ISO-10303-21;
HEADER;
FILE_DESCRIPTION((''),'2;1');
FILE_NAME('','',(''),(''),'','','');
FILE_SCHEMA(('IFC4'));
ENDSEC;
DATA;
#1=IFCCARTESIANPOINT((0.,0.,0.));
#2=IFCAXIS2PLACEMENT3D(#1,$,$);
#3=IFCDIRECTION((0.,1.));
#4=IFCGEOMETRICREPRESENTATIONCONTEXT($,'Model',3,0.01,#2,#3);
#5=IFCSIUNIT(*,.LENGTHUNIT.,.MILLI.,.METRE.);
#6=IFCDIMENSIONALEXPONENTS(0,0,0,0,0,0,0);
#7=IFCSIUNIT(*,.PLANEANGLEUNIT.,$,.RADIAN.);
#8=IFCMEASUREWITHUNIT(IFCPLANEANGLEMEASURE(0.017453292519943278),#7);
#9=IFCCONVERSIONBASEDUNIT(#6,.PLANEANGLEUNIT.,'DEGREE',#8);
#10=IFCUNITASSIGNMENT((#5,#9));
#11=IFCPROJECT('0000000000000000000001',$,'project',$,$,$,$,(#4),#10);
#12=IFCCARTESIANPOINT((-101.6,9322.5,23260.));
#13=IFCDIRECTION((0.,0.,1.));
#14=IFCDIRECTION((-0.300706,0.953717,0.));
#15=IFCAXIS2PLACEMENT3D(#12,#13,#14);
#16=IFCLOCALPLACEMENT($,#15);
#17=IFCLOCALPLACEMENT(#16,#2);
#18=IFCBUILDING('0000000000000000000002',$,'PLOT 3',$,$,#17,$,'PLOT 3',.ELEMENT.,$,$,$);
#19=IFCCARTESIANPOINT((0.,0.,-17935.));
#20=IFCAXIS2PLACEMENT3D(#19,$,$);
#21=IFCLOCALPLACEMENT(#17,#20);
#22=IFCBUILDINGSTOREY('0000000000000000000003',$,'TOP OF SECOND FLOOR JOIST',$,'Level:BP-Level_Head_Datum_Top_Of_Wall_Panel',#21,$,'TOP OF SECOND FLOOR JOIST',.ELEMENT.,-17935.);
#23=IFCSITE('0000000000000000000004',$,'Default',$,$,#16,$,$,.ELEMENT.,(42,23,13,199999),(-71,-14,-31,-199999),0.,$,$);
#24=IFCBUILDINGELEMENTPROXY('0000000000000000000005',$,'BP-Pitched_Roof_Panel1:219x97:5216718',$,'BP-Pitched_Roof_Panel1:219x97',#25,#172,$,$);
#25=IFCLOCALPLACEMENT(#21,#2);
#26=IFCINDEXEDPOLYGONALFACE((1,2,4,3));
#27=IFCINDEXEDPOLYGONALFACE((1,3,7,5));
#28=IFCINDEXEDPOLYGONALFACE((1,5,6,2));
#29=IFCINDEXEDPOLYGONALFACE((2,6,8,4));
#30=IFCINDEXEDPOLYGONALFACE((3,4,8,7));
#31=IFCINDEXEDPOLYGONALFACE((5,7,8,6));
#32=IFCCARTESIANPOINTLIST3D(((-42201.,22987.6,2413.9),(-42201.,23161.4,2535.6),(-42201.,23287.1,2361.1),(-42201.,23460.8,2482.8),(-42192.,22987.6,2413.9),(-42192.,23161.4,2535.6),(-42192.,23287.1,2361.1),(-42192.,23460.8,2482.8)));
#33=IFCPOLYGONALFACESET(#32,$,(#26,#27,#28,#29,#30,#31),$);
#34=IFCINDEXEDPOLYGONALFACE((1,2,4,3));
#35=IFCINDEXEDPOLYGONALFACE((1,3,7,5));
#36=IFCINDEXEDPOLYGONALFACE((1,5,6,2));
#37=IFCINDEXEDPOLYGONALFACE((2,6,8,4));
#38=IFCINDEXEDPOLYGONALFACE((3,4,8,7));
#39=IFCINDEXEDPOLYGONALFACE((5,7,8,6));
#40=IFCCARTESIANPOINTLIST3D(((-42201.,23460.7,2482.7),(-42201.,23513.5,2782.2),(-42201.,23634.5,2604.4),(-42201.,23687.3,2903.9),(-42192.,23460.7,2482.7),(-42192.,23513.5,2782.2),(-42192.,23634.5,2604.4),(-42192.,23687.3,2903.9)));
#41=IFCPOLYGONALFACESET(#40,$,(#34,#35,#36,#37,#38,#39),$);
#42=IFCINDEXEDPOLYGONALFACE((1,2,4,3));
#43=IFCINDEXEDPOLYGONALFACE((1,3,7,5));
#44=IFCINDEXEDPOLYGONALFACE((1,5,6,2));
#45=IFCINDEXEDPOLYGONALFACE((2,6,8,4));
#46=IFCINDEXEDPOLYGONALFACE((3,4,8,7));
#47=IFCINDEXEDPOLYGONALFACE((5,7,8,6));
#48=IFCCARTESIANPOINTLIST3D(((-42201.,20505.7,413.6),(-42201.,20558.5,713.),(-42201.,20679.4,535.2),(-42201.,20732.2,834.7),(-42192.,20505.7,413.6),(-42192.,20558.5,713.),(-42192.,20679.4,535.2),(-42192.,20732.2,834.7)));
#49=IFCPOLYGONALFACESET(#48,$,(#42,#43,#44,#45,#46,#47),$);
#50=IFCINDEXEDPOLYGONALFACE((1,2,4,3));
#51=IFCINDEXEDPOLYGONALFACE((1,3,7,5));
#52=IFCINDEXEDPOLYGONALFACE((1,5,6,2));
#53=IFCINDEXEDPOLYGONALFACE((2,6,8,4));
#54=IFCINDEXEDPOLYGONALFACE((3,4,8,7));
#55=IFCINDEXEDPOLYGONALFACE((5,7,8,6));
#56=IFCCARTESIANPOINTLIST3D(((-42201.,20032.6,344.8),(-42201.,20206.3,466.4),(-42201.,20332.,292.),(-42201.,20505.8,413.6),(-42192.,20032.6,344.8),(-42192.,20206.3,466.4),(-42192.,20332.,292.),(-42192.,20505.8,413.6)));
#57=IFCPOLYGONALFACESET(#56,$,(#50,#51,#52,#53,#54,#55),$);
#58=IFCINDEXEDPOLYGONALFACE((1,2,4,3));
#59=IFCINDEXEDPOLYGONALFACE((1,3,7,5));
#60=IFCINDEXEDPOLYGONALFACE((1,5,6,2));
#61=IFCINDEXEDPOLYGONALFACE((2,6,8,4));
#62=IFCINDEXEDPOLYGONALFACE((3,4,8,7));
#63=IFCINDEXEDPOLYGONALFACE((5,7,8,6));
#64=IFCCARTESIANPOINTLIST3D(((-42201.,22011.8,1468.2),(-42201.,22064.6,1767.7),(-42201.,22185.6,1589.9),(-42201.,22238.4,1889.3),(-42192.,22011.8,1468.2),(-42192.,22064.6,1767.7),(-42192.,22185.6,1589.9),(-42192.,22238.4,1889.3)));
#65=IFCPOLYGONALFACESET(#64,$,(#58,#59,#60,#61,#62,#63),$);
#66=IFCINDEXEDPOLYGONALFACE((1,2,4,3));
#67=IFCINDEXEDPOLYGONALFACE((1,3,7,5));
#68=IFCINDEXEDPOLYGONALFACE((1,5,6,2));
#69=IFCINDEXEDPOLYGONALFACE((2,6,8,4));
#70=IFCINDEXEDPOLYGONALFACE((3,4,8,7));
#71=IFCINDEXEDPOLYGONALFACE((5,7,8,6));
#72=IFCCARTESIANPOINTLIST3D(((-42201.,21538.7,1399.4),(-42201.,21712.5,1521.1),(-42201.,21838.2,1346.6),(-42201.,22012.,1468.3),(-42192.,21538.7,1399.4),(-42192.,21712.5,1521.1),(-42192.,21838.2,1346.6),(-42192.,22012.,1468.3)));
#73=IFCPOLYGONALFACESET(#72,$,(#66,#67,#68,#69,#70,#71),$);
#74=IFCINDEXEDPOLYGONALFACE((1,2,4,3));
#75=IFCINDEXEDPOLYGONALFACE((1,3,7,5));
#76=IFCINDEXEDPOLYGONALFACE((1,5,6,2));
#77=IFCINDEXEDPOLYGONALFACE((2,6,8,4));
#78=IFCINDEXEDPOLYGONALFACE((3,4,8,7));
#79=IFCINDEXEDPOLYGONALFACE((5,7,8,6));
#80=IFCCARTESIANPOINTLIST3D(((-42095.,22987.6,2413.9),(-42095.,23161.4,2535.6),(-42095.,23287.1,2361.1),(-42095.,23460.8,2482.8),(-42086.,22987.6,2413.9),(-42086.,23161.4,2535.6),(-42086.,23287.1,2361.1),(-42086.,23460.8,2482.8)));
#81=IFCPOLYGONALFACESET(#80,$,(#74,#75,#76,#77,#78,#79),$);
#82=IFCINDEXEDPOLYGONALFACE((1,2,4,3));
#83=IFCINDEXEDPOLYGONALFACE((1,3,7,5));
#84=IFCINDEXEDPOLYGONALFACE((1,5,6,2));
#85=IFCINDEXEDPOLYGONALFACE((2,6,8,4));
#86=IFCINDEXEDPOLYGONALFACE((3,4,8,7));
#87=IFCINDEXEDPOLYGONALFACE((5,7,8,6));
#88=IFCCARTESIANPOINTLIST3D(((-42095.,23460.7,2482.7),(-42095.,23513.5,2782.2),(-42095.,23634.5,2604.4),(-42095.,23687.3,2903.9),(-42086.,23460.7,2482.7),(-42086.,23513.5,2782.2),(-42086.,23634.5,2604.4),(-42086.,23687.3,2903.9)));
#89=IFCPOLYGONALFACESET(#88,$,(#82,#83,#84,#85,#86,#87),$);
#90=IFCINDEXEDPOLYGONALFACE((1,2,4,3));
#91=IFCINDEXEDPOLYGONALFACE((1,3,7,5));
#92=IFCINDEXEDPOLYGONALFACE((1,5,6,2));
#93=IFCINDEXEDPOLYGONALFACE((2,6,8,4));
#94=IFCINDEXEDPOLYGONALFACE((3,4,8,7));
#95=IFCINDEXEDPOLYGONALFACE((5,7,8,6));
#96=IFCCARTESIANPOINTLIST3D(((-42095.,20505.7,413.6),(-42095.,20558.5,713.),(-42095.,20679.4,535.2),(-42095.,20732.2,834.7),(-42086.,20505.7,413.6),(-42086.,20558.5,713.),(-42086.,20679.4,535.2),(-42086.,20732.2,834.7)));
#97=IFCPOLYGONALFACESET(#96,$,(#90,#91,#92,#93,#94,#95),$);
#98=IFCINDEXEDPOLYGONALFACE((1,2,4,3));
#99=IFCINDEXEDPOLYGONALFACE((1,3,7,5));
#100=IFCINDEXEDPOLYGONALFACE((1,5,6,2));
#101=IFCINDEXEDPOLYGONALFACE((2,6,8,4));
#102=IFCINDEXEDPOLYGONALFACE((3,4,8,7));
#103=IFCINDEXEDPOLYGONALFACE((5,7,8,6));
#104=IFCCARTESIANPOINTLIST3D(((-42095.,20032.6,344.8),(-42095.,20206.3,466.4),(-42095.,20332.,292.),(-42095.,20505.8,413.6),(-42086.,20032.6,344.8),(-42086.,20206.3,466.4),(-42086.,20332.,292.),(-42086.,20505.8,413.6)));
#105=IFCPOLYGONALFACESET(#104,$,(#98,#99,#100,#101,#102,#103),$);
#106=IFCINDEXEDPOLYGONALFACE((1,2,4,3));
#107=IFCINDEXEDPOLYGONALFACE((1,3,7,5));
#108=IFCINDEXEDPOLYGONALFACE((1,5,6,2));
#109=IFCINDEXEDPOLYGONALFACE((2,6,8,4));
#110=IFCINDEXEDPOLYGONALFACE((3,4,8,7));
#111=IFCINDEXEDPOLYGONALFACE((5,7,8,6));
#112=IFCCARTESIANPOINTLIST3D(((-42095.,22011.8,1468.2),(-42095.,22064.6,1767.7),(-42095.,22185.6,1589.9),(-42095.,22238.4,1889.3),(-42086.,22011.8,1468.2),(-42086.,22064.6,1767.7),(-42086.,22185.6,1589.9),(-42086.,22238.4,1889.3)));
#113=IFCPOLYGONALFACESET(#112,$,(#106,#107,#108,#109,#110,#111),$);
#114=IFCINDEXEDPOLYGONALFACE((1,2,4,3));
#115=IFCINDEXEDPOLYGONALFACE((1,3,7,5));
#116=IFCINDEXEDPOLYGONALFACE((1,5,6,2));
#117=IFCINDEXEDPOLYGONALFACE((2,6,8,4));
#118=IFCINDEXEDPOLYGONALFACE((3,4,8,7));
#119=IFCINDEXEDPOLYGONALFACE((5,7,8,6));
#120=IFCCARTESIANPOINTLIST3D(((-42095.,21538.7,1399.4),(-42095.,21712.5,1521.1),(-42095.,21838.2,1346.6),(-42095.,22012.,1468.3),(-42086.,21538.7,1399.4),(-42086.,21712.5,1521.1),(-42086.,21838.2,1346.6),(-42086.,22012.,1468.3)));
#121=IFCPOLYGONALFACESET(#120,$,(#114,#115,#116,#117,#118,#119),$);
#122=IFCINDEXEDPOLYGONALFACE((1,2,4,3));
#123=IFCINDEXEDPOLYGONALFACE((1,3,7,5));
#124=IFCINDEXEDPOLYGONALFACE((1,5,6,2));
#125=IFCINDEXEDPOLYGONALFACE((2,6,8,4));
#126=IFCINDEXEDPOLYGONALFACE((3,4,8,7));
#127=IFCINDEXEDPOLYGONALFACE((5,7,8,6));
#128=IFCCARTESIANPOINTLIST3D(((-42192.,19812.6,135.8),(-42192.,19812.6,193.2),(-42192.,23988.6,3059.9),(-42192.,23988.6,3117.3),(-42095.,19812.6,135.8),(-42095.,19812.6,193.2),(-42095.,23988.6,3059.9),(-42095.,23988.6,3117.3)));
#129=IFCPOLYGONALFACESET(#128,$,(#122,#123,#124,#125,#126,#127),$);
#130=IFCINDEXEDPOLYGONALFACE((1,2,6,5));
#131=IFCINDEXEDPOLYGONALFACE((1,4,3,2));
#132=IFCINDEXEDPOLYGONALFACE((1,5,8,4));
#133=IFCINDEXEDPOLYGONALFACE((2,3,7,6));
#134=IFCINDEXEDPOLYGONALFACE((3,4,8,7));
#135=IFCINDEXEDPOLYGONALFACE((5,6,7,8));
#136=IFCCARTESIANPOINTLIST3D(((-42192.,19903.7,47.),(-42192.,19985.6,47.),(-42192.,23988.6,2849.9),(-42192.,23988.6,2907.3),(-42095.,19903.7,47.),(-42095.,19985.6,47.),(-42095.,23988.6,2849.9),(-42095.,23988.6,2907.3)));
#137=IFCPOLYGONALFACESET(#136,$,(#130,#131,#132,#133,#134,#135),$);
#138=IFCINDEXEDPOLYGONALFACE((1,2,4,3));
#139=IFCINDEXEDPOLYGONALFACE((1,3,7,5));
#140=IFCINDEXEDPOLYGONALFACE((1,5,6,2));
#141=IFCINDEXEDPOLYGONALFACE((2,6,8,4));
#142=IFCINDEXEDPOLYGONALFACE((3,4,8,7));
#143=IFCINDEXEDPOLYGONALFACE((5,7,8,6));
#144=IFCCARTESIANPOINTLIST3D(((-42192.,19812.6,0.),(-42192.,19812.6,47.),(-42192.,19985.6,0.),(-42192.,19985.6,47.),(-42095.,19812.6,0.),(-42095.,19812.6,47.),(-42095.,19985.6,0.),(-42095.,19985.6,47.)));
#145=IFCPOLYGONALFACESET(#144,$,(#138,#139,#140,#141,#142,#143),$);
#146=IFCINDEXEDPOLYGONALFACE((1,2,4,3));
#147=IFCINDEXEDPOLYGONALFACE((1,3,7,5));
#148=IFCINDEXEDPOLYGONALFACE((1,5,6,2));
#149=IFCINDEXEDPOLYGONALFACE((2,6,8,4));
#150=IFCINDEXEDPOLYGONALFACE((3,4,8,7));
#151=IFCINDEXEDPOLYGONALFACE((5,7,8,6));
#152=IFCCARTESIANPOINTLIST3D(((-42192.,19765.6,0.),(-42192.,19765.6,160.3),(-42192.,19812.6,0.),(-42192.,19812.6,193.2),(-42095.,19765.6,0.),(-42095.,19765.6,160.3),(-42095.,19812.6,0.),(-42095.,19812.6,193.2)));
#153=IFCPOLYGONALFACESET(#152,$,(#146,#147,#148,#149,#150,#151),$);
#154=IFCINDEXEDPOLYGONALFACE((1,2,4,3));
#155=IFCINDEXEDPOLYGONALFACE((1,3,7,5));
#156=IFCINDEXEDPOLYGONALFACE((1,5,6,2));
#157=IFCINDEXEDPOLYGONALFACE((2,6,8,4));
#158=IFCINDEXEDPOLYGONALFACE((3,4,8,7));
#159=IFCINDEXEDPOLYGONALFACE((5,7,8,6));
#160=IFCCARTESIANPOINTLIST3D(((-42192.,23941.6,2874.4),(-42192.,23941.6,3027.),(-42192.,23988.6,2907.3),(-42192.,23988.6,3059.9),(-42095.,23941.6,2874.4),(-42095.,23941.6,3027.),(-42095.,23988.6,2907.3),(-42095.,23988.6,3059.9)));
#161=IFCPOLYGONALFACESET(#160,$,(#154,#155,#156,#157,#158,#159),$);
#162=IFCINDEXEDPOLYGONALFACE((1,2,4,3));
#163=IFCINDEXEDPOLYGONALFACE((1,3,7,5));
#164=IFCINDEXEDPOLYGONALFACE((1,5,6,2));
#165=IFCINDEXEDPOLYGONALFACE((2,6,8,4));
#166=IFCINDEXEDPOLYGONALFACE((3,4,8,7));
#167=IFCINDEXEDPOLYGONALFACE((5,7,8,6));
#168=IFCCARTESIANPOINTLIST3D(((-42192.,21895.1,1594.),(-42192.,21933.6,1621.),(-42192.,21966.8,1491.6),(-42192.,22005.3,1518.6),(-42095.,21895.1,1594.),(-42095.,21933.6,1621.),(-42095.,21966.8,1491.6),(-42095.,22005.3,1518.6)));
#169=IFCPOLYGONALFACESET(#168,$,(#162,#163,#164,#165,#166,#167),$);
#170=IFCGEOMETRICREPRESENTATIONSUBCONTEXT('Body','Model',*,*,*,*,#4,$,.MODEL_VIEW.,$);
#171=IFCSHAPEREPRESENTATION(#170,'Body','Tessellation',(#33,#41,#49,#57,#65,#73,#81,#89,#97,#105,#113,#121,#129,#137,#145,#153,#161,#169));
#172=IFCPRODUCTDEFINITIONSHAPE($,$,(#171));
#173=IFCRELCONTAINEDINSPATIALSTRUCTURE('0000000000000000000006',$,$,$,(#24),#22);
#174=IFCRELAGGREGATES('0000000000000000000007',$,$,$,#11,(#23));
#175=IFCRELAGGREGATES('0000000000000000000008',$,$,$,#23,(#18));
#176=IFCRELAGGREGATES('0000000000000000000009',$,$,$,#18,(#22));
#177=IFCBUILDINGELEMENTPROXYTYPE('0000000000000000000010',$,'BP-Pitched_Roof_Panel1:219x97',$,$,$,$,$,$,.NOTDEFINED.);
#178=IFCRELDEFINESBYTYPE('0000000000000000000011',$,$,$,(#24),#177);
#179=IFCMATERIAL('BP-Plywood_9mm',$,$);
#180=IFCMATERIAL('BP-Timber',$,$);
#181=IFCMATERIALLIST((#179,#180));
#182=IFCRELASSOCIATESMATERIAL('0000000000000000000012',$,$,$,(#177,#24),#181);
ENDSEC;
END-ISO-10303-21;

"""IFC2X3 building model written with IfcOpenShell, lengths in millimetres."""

from ifc_helpers import new_model, entity, si_unit, converted_unit, direction, frame, frame_2d, origin, origin_2d_with_axis, place, context, subcontext, project, spatial, polyline, rectangle, outline, extrude, source, transform, mapped, material, material_list, type_object, type_shapes, element, save


model = new_model("IFC2X3")

# Units and contexts
model_context = context("Model", 3, precision=0.01, world=origin(), true_north=direction((0.0, 1.0)))
body_context = subcontext(model_context, "Body", "Model", "MODEL_VIEW")
ifc_project = project(units=[si_unit("LENGTHUNIT", "METRE", prefix="MILLI"), converted_unit("PLANEANGLEUNIT", "DEGREE", entity("IfcPlaneAngleMeasure", 0.017453292519943278), si_unit("PLANEANGLEUNIT", "RADIAN"), dimensions=[0, 0, 0, 0, 0, 0, 0])], contexts=[model_context])

# Site, building, storey
site_placement = place(None, frame((-101.6, 9322.5, 23260.0), z_axis=(0.0, 0.0, 1.0), x_axis=(-0.300706, 0.953717, 0.0)))
site = spatial("IfcSite", under=ifc_project, at=site_placement, Name="Default", CompositionType="ELEMENT", RefLatitude=(42, 23, 13, 199999), RefLongitude=(-71, -14, -31, -199999), RefElevation=0.0)
building_placement = place(site_placement, origin())
building = spatial("IfcBuilding", under=site, at=building_placement, Name="PLOT 3", LongName="PLOT 3", CompositionType="ELEMENT")
storey_placement = place(building_placement, frame((0.0, 0.0, -17935.0)))
storey = spatial("IfcBuildingStorey", under=building, at=storey_placement, Name="TOP OF SECOND FLOOR JOIST", ObjectType="Level:BP-Level_Head_Datum_Top_Of_Wall_Panel", LongName="TOP OF SECOND FLOOR JOIST", CompositionType="ELEMENT", Elevation=-17935.0)

# Building element proxy
ifc_material_1 = material(Name="BP-Timber")
ifc_material_2 = material(Name="BP-Plywood_9mm")
ifc_material_list = material_list([ifc_material_2, ifc_material_1])
building_element_proxy_type_1 = type_object("IfcBuildingElementProxyType", Name="BP-Pitched_Roof_Panel1:219x97", PredefinedType="NOTDEFINED", material=ifc_material_list)
shared_shape_1 = source(origin(), body_context, "Body", "SweptSolid", [
    extrude(outline(polyline([(-77.0, -75.0), (227.0, -75.0), (77.0, 75.0), (-227.0, 75.0), (-77.0, -75.0)])), frame((36.3, 3947.0, 2448.4), z_axis=(0.0, 1.0, 0.0), x_axis=(-0.984808, 0.0, 0.173648)), (0.0, 0.0, 1.0), 9.0),
    extrude(outline(polyline([(1.4, -107.5), (213.6, -107.5), (-1.4, 107.5), (-213.6, 107.5), (1.4, -107.5)])), frame((386.1, 3947.0, 2693.3), z_axis=(0.0, 1.0, 0.0), x_axis=(-0.819152, 0.0, -0.573576)), (0.0, 0.0, 1.0), 9.0),
    extrude(outline(polyline([(1.4, -107.5), (213.6, -107.5), (-1.4, 107.5), (-213.6, 107.5), (1.4, -107.5)])), frame((-2569.0, 3947.0, 624.1), z_axis=(0.0, 1.0, 0.0), x_axis=(-0.819152, 0.0, -0.573576)), (0.0, 0.0, 1.0), 9.0),
    extrude(outline(polyline([(-77.0, -75.0), (227.0, -75.0), (77.0, 75.0), (-227.0, 75.0), (-77.0, -75.0)])), frame((-2918.8, 3947.0, 379.2), z_axis=(0.0, 1.0, 0.0), x_axis=(-0.984808, 0.0, 0.173648)), (0.0, 0.0, 1.0), 9.0),
    extrude(outline(polyline([(1.4, -107.5), (213.6, -107.5), (-1.4, 107.5), (-213.6, 107.5), (1.4, -107.5)])), frame((-1062.8, 3947.0, 1678.8), z_axis=(0.0, 1.0, 0.0), x_axis=(-0.819152, 0.0, -0.573576)), (0.0, 0.0, 1.0), 9.0),
    extrude(outline(polyline([(-77.0, -75.0), (227.0, -75.0), (77.0, 75.0), (-227.0, 75.0), (-77.0, -75.0)])), frame((-1412.6, 3947.0, 1433.9), z_axis=(0.0, 1.0, 0.0), x_axis=(-0.984808, 0.0, 0.173648)), (0.0, 0.0, 1.0), 9.0),
    extrude(outline(polyline([(-77.0, -75.0), (227.0, -75.0), (77.0, 75.0), (-227.0, 75.0), (-77.0, -75.0)])), frame((36.3, 3841.0, 2448.4), z_axis=(0.0, 1.0, 0.0), x_axis=(-0.984808, 0.0, 0.173648)), (0.0, 0.0, 1.0), 9.0),
    extrude(outline(polyline([(1.4, -107.5), (213.6, -107.5), (-1.4, 107.5), (-213.6, 107.5), (1.4, -107.5)])), frame((386.1, 3841.0, 2693.3), z_axis=(0.0, 1.0, 0.0), x_axis=(-0.819152, 0.0, -0.573576)), (0.0, 0.0, 1.0), 9.0),
    extrude(outline(polyline([(1.4, -107.5), (213.6, -107.5), (-1.4, 107.5), (-213.6, 107.5), (1.4, -107.5)])), frame((-2569.0, 3841.0, 624.1), z_axis=(0.0, 1.0, 0.0), x_axis=(-0.819152, 0.0, -0.573576)), (0.0, 0.0, 1.0), 9.0),
    extrude(outline(polyline([(-77.0, -75.0), (227.0, -75.0), (77.0, 75.0), (-227.0, 75.0), (-77.0, -75.0)])), frame((-2918.8, 3841.0, 379.2), z_axis=(0.0, 1.0, 0.0), x_axis=(-0.984808, 0.0, 0.173648)), (0.0, 0.0, 1.0), 9.0),
    extrude(outline(polyline([(1.4, -107.5), (213.6, -107.5), (-1.4, 107.5), (-213.6, 107.5), (1.4, -107.5)])), frame((-1062.8, 3841.0, 1678.8), z_axis=(0.0, 1.0, 0.0), x_axis=(-0.819152, 0.0, -0.573576)), (0.0, 0.0, 1.0), 9.0),
    extrude(outline(polyline([(-77.0, -75.0), (227.0, -75.0), (77.0, 75.0), (-227.0, 75.0), (-77.0, -75.0)])), frame((-1412.6, 3841.0, 1433.9), z_axis=(0.0, 1.0, 0.0), x_axis=(-0.984808, 0.0, 0.173648)), (0.0, 0.0, 1.0), 9.0),
    extrude(outline(polyline([(-1490.7, -2088.0), (-1433.3, -2088.0), (1490.7, 2088.0), (1433.3, 2088.0), (-1490.7, -2088.0)])), frame((-1287.3, 3850.0, 1626.6), z_axis=(0.0, 1.0, 0.0), x_axis=(0.0, 0.0, -1.0)), (0.0, 0.0, 1.0), 97.0),
    extrude(outline(polyline([(-1444.5, -2022.0), (-1387.1, -2022.0), (1415.8, 1981.0), (1415.8, 2063.0), (-1444.5, -2022.0)])), frame((-1221.3, 3850.0, 1462.8), z_axis=(0.0, 1.0, 0.0), x_axis=(0.0, 0.0, -1.0)), (0.0, 0.0, 1.0), 97.0),
    extrude(rectangle(XDim=97.0, YDim=173.0, at=origin_2d_with_axis()), frame((-3288.8, 3898.5, 0.0), z_axis=(0.0, 0.0, 1.0), x_axis=(0.0, 1.0, 0.0)), (0.0, 0.0, 1.0), 47.0),
    extrude(outline(polyline([(22.0, -72.4), (79.4, -72.4), (-31.4, 85.9), (-69.9, 58.9), (22.0, -72.4)])), frame((-3398.8, 3850.0, 88.4), z_axis=(0.0, 1.0, 0.0), x_axis=(0.819152, 0.0, 0.573576)), (0.0, 0.0, 1.0), 97.0),
    extrude(outline(polyline([(15.1, -62.5), (72.5, -62.5), (-15.1, 62.5), (-72.5, 62.5), (15.1, -62.5)])), frame((777.2, 3850.0, 2967.2), z_axis=(0.0, 1.0, 0.0), x_axis=(0.819152, 0.0, 0.573576)), (0.0, 0.0, 1.0), 97.0),
    extrude(rectangle(XDim=47.0, YDim=97.0, at=frame_2d((0.0, 0.0), x_axis=(0.0, 1.0))), frame((-1201.9, 3898.5, 1505.1), z_axis=(-0.573576, 0.0, 0.819152), x_axis=(0.0, 1.0, 0.0)), (0.0, 0.0, 1.0), 125.0),
])
type_shapes(building_element_proxy_type_1, [shared_shape_1])
for number, where, z_axis, x_axis, name in (
    (1, (-38245.0, 23187.9, 0.0), (0.0, 0.0, 1.0), (0.0, 1.0, 0.0), "BP-Pitched_Roof_Panel1:219x97:5216718"),
):
    element("IfcBuildingElementProxy", number, at=place(storey_placement, frame(where, z_axis=z_axis, x_axis=x_axis)), inside=storey, type_object=building_element_proxy_type_1, material=ifc_material_list, Name=name, ObjectType="BP-Pitched_Roof_Panel1:219x97", context=body_context, shape_type="MappedRepresentation", body=[
        mapped(shared_shape_1, transform((0.0, 0.0, 0.0), scale=1.0)),
    ])

save(model, "model.ifc")
